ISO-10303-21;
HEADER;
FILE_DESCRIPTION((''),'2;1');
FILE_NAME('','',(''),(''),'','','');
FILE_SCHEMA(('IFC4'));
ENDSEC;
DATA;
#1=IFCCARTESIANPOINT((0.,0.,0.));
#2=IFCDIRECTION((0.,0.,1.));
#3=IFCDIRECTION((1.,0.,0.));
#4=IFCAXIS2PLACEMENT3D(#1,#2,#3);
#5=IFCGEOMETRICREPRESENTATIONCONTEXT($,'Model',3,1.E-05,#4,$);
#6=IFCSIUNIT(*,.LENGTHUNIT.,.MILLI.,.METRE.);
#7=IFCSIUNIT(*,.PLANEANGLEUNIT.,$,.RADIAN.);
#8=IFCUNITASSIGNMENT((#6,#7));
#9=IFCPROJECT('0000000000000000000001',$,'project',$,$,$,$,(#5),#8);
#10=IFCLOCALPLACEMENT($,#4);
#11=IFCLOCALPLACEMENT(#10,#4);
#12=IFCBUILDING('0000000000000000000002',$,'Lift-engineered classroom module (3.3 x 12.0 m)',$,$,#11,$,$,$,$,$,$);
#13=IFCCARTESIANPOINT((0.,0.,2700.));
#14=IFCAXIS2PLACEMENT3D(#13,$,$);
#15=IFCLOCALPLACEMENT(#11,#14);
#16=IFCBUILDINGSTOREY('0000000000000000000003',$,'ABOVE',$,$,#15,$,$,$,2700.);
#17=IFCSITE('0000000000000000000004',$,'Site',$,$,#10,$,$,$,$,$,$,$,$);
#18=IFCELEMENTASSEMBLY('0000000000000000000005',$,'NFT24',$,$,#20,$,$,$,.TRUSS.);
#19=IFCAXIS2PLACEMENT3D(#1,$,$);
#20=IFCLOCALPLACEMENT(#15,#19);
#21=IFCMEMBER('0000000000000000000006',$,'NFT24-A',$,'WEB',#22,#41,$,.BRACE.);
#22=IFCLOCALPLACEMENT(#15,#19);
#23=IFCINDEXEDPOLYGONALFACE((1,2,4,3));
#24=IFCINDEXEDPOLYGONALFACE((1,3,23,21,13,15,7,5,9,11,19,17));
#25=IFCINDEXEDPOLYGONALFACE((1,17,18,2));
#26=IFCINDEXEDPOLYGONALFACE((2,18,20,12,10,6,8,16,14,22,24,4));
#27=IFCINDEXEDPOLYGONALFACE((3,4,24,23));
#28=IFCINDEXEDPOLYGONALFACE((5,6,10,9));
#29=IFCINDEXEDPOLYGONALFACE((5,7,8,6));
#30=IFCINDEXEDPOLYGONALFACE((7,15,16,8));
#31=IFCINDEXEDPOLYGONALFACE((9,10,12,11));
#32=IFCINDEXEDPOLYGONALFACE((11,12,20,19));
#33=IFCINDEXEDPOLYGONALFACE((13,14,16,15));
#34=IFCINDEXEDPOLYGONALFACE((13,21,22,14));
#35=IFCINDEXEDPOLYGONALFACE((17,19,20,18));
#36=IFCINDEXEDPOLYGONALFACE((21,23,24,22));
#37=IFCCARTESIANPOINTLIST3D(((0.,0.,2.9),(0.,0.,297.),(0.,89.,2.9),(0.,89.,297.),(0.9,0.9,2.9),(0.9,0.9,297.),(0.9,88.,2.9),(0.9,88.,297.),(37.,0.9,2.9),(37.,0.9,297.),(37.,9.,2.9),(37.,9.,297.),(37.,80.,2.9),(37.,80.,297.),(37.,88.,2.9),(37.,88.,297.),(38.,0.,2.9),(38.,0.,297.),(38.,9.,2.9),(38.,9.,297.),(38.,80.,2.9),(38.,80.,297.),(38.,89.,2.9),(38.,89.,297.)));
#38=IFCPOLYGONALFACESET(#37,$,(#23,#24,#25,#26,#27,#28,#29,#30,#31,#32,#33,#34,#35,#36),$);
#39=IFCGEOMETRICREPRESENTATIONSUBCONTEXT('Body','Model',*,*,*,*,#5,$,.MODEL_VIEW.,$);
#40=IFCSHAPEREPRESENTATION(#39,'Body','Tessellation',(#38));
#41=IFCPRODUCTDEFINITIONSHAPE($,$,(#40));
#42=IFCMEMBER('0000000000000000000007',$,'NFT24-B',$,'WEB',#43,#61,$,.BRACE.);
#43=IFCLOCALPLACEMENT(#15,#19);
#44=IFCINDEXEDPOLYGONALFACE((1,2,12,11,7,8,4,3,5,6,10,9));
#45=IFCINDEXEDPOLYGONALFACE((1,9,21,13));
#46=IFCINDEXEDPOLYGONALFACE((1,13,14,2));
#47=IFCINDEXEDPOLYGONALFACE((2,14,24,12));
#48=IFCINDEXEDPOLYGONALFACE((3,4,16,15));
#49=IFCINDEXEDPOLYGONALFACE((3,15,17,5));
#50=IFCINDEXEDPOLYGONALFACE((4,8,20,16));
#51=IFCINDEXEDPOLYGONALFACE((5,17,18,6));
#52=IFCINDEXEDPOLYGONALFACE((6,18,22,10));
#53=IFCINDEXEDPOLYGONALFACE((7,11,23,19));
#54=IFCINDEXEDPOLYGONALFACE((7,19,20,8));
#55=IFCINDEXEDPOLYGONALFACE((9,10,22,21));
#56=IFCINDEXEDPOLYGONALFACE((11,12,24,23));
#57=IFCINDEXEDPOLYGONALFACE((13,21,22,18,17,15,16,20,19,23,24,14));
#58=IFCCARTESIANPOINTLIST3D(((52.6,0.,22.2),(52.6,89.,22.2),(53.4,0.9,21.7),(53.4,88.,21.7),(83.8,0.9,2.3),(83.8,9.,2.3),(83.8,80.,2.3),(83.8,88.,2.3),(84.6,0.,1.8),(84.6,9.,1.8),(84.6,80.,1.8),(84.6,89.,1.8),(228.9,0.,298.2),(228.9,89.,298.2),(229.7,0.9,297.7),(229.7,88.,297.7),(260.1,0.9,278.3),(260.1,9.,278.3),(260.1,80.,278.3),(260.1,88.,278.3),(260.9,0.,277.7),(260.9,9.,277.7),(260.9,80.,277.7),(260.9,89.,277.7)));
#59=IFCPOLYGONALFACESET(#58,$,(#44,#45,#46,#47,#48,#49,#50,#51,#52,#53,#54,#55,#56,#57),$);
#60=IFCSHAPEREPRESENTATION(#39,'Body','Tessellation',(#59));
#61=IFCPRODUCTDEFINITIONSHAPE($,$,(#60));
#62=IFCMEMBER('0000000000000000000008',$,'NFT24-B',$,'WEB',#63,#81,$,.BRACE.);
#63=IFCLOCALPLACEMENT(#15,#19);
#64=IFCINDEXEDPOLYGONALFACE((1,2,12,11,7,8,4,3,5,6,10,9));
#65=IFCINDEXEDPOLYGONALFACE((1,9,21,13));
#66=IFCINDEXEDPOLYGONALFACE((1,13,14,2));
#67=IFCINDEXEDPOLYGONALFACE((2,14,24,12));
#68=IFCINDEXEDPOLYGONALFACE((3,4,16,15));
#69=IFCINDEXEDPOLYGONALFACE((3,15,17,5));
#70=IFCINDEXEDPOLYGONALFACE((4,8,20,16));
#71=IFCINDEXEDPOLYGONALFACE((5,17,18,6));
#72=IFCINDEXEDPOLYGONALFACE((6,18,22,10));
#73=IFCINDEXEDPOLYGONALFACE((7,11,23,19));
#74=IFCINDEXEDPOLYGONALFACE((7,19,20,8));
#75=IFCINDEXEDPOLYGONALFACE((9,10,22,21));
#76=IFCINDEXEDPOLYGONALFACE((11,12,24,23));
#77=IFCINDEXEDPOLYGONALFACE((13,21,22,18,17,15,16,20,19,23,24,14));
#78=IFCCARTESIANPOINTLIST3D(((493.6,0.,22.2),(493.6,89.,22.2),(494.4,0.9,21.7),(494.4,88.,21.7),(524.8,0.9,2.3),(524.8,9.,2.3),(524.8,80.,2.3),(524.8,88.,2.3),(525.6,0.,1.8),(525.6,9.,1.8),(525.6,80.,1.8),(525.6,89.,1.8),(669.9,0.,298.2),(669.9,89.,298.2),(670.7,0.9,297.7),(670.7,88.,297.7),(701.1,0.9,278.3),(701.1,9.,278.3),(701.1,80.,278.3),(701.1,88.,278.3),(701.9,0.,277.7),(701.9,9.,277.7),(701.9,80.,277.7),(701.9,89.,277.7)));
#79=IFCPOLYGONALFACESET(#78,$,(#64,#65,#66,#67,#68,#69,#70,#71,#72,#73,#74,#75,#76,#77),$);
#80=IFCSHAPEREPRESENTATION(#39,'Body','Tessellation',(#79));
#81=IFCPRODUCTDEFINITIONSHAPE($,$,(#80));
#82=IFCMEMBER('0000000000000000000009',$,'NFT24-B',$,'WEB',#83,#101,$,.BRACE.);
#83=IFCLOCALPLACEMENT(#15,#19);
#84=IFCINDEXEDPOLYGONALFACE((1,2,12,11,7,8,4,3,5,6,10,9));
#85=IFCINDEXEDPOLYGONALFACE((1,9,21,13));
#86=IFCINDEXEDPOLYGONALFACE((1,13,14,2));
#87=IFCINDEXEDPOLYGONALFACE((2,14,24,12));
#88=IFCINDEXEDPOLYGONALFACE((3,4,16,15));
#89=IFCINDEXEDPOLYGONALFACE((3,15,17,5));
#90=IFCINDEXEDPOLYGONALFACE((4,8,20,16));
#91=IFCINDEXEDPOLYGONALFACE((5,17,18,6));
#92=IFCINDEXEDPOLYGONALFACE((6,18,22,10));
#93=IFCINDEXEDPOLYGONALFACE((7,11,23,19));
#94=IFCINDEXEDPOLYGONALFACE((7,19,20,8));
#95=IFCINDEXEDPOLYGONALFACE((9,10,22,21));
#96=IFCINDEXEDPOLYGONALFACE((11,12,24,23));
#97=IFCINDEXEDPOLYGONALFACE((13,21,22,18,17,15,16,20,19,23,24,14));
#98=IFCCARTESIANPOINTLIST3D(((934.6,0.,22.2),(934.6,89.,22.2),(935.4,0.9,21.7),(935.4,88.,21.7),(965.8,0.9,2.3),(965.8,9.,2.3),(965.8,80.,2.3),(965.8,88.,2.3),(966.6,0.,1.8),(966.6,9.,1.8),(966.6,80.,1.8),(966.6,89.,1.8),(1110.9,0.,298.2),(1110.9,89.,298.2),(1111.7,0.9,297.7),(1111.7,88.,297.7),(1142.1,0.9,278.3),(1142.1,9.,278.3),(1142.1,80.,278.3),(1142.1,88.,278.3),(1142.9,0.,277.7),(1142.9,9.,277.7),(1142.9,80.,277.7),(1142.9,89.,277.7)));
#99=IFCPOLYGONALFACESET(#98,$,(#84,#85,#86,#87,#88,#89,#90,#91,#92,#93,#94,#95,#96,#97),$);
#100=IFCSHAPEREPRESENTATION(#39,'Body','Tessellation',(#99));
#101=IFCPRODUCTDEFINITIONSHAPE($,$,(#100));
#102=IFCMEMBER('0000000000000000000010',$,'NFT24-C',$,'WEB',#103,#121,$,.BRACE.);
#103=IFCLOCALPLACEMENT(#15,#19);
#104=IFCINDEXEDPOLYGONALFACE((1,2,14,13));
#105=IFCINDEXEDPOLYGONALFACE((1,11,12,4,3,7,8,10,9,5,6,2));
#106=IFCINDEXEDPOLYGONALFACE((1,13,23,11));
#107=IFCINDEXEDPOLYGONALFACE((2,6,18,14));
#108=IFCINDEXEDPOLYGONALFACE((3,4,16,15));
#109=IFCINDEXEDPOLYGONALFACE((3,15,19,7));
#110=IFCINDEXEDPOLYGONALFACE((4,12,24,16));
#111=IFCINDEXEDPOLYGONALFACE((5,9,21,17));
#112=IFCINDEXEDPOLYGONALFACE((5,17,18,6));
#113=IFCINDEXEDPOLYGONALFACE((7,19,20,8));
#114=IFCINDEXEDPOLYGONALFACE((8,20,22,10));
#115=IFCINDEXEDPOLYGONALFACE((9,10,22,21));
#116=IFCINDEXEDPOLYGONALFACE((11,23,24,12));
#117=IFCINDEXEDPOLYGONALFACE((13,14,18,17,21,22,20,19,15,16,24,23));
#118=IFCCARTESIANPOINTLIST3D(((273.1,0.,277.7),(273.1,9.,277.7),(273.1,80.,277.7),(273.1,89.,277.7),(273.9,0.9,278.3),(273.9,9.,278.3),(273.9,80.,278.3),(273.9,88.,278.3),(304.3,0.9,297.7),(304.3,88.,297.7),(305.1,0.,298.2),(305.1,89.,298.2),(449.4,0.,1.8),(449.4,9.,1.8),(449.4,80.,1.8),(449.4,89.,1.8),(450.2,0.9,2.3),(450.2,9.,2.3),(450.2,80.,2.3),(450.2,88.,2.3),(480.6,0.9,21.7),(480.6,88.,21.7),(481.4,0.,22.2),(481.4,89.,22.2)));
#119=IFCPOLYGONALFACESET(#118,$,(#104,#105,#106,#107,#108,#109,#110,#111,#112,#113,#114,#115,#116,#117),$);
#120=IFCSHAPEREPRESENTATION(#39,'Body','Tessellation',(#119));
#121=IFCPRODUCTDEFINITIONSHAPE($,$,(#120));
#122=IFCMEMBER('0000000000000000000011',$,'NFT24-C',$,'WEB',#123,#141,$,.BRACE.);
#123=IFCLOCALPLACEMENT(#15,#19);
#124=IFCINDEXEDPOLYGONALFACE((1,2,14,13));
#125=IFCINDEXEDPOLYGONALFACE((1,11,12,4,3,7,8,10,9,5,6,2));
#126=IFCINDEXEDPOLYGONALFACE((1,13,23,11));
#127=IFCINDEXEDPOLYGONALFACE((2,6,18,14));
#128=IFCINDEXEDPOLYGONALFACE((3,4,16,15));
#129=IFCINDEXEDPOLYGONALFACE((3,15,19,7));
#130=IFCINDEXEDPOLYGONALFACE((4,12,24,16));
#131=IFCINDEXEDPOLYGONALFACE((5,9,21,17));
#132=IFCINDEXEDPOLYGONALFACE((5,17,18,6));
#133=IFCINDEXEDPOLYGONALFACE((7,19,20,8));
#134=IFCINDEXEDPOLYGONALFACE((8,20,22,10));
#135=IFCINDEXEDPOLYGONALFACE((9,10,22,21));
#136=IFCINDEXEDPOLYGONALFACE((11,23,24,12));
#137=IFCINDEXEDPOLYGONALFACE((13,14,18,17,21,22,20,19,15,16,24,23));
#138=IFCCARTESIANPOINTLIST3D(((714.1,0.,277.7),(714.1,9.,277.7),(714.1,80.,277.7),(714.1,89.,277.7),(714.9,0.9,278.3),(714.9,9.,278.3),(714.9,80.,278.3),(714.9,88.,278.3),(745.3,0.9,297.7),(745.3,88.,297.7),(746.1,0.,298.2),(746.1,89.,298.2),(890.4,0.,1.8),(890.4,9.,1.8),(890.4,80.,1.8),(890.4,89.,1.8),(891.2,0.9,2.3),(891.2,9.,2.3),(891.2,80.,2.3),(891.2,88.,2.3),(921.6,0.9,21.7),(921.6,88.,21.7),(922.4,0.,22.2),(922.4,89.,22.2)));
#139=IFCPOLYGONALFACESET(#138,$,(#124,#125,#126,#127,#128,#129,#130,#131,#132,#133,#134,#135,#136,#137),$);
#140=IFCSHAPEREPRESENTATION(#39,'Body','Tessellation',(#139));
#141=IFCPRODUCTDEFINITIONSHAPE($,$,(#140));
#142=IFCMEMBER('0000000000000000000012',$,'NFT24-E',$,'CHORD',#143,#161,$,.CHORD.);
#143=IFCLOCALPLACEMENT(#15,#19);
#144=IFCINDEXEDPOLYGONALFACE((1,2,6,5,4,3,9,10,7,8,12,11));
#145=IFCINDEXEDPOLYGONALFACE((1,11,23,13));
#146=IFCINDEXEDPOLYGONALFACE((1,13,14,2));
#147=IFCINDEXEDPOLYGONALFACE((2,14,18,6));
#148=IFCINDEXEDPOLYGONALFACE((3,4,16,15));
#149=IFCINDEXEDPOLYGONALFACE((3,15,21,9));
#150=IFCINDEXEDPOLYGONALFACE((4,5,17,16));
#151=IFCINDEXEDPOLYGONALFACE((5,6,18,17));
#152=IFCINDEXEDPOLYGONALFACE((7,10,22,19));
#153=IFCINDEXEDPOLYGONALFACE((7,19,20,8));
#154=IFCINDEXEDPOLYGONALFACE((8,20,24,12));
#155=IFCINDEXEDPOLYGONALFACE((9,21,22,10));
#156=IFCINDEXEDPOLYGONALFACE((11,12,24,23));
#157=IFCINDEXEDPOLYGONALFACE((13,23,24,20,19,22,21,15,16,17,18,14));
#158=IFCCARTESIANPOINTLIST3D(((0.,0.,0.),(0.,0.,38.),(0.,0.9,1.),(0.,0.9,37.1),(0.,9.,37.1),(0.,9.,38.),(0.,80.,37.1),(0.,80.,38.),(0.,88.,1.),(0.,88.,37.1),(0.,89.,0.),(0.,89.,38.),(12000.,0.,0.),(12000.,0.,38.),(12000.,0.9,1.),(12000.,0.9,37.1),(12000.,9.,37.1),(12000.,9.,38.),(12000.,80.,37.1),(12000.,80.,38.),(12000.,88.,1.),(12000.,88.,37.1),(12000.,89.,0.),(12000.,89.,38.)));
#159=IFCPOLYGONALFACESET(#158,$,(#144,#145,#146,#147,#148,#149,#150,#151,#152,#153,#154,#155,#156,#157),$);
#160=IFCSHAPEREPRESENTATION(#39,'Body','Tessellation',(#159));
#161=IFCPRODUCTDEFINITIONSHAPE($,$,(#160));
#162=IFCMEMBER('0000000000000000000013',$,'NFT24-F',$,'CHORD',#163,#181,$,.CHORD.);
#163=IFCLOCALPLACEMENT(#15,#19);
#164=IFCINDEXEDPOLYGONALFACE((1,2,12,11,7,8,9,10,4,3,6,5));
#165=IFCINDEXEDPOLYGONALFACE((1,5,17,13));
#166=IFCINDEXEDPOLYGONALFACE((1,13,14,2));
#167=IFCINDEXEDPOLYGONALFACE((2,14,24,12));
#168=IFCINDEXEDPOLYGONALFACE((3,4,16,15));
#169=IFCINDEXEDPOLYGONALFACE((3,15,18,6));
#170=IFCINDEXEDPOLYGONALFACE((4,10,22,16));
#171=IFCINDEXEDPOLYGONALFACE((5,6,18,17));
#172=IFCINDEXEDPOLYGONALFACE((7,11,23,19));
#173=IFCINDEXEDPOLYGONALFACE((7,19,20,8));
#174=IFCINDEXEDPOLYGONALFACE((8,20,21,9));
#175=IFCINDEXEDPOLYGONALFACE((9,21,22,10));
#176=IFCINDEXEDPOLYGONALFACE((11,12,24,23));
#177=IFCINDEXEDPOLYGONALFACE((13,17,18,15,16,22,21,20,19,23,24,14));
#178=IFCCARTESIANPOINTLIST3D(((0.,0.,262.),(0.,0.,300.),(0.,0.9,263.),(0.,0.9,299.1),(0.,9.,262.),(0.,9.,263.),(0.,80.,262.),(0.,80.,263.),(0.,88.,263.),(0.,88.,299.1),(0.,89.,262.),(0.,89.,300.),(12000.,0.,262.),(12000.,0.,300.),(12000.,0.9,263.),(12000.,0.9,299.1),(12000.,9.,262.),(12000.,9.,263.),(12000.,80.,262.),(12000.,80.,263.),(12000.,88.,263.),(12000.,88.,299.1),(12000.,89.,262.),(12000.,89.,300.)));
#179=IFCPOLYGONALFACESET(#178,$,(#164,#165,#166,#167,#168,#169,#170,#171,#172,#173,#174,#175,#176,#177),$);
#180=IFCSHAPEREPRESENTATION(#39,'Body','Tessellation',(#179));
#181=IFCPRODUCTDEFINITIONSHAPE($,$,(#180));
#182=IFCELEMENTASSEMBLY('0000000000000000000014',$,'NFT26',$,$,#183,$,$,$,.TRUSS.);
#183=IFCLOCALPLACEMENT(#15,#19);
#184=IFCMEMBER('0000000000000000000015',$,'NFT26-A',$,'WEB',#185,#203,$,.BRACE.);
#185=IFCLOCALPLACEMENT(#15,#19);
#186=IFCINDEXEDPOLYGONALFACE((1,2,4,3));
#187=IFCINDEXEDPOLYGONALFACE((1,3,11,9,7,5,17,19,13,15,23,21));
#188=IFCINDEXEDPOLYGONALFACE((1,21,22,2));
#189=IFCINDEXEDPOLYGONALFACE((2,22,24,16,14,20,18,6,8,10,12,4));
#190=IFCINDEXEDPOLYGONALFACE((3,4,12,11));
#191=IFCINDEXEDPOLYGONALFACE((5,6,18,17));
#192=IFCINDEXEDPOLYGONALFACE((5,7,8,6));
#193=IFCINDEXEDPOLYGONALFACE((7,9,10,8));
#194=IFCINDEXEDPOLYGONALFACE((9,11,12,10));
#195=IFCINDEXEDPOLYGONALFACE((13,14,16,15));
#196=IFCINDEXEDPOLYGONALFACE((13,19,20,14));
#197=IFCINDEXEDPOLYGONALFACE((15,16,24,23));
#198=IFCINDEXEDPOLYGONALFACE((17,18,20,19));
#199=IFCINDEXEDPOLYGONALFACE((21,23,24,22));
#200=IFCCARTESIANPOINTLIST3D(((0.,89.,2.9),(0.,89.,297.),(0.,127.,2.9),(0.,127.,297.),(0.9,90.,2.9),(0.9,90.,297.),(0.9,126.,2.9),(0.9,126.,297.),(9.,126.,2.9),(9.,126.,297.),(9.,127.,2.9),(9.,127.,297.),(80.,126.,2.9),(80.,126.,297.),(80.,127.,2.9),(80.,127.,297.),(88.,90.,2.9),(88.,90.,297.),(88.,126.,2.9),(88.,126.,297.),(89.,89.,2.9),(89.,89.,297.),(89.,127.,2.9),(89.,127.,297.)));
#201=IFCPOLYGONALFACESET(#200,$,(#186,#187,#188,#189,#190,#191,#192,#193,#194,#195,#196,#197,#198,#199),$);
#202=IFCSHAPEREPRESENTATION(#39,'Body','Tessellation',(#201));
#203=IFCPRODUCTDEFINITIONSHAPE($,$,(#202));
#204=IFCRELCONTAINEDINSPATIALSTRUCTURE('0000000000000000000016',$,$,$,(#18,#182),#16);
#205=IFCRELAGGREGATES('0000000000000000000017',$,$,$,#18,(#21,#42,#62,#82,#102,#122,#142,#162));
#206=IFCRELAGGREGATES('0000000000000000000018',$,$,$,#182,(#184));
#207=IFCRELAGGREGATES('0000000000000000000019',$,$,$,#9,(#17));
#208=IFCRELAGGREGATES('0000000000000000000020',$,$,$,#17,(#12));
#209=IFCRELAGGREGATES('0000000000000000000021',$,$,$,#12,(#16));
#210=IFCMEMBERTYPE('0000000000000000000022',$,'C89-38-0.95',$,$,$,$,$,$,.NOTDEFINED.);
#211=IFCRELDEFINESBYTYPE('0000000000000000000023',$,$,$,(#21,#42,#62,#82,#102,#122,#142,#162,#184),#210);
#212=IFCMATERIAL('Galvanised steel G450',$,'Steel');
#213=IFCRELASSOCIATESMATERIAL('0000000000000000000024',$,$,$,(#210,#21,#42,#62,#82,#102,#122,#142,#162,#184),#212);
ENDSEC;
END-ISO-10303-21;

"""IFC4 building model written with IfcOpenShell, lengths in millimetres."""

from ifc_helpers import new_model, si_unit, frame, origin, origin_with_axes, origin_2d, place, context, subcontext, project, spatial, c_section, extrude, material, material_profile, profile_set, profile_usage, type_object, element, aggregate, save


model = new_model("IFC4")

# Units and contexts
model_context = context("Model", 3, precision=1e-05, world=origin_with_axes())
body_context = subcontext(model_context, "Body", "Model", "MODEL_VIEW")
ifc_project = project(units=[si_unit("LENGTHUNIT", "METRE", prefix="MILLI"), si_unit("PLANEANGLEUNIT", "RADIAN")], contexts=[model_context])

# Site, building, storey
site_placement = place(None, origin_with_axes())
site = spatial("IfcSite", under=ifc_project, at=site_placement, Name="Site")
building_placement = place(site_placement, origin_with_axes())
building = spatial("IfcBuilding", under=site, at=building_placement, Name="Lift-engineered classroom module (3.3 x 12.0 m)")
storey_placement = place(building_placement, frame((0.0, 0.0, 2700.0)))
storey = spatial("IfcBuildingStorey", under=building, at=storey_placement, Name="ABOVE", Elevation=2700.0)

# Element assemblies, members
assembly_1_placement = place(storey_placement, frame((0.0, 44.5, 0.0)))
assembly_1 = element("IfcElementAssembly", 1, at=assembly_1_placement, inside=storey, Name="NFT24", PredefinedType="TRUSS")
ifc_material = material(Name="Galvanised steel G450", Category="Steel")
ifc_material_profile = material_profile(ifc_material, c_section(Depth=89.0, Width=38.0, WallThickness=0.9, Girth=9.0, at=origin_2d()), Name="C89-38-0.95")
ifc_profile_set = profile_set([ifc_material_profile], Name="C89-38-0.95")
ifc_profile_usage = profile_usage(ifc_profile_set)
member_type = type_object("IfcMemberType", Name="C89-38-0.95", PredefinedType="NOTDEFINED", material=ifc_profile_set)
member_1_placement = place(assembly_1_placement, frame((19.0, 0.0, 2.9), z_axis=(0.0, 0.0, 1.0), x_axis=(1.0, 0.0, 0.0)))
member_1 = element("IfcMember", 2, at=member_1_placement, type_object=member_type, material=ifc_profile_usage, Name="NFT24-A", ObjectType="WEB", PredefinedType="BRACE", context=body_context, shape_type="SweptSolid", body=[
    extrude(c_section(Depth=89.0, Width=38.0, WallThickness=0.9, Girth=9.0, at=origin_2d()), origin(), (0.0, 0.0, 1.0), 294.1),
])
member_2_placement = place(assembly_1_placement, frame((68.6, 0.0, 12.0), z_axis=(0.538459, 0.0, 0.842652), x_axis=(0.842652, 0.0, -0.538459)))
member_2 = element("IfcMember", 3, at=member_2_placement, type_object=member_type, material=ifc_profile_usage, Name="NFT24-B", ObjectType="WEB", PredefinedType="BRACE", context=body_context, shape_type="SweptSolid", body=[
    extrude(c_section(Depth=89.0, Width=38.0, WallThickness=0.9, Girth=9.0, at=origin_2d()), origin(), (0.0, 0.0, 1.0), 327.5),
])
member_3_placement = place(assembly_1_placement, frame((509.6, 0.0, 12.0), z_axis=(0.538459, 0.0, 0.842652), x_axis=(0.842652, 0.0, -0.538459)))
member_3 = element("IfcMember", 4, at=member_3_placement, type_object=member_type, material=ifc_profile_usage, Name="NFT24-B", ObjectType="WEB", PredefinedType="BRACE", context=body_context, shape_type="SweptSolid", body=[
    extrude(c_section(Depth=89.0, Width=38.0, WallThickness=0.9, Girth=9.0, at=origin_2d()), origin(), (0.0, 0.0, 1.0), 327.5),
])
member_4_placement = place(assembly_1_placement, frame((950.6, 0.0, 12.0), z_axis=(0.538459, 0.0, 0.842652), x_axis=(0.842652, 0.0, -0.538459)))
member_4 = element("IfcMember", 5, at=member_4_placement, type_object=member_type, material=ifc_profile_usage, Name="NFT24-B", ObjectType="WEB", PredefinedType="BRACE", context=body_context, shape_type="SweptSolid", body=[
    extrude(c_section(Depth=89.0, Width=38.0, WallThickness=0.9, Girth=9.0, at=origin_2d()), origin(), (0.0, 0.0, 1.0), 327.5),
])
member_5_placement = place(assembly_1_placement, frame((465.4, 0.0, 12.0), z_axis=(-0.538459, 0.0, 0.842652), x_axis=(-0.842652, 0.0, -0.538459)))
member_5 = element("IfcMember", 6, at=member_5_placement, type_object=member_type, material=ifc_profile_usage, Name="NFT24-C", ObjectType="WEB", PredefinedType="BRACE", context=body_context, shape_type="SweptSolid", body=[
    extrude(c_section(Depth=89.0, Width=38.0, WallThickness=0.9, Girth=9.0, at=origin_2d()), origin(), (0.0, 0.0, 1.0), 327.5),
])
member_6_placement = place(assembly_1_placement, frame((906.4, 0.0, 12.0), z_axis=(-0.538459, 0.0, 0.842652), x_axis=(-0.842652, 0.0, -0.538459)))
member_6 = element("IfcMember", 7, at=member_6_placement, type_object=member_type, material=ifc_profile_usage, Name="NFT24-C", ObjectType="WEB", PredefinedType="BRACE", context=body_context, shape_type="SweptSolid", body=[
    extrude(c_section(Depth=89.0, Width=38.0, WallThickness=0.9, Girth=9.0, at=origin_2d()), origin(), (0.0, 0.0, 1.0), 327.5),
])
member_7_placement = place(assembly_1_placement, frame((0.0, 0.0, 19.0), z_axis=(1.0, 0.0, 0.0), x_axis=(0.0, 0.0, 1.0)))
member_7 = element("IfcMember", 8, at=member_7_placement, type_object=member_type, material=ifc_profile_usage, Name="NFT24-E", ObjectType="CHORD", PredefinedType="CHORD", context=body_context, shape_type="SweptSolid", body=[
    extrude(c_section(Depth=89.0, Width=38.0, WallThickness=0.9, Girth=9.0, at=origin_2d()), origin(), (0.0, 0.0, 1.0), 12000.0),
])
member_8_placement = place(assembly_1_placement, frame((0.0, 0.0, 281.0), z_axis=(1.0, 0.0, 0.0), x_axis=(0.0, 0.0, -1.0)))
member_8 = element("IfcMember", 9, at=member_8_placement, type_object=member_type, material=ifc_profile_usage, Name="NFT24-F", ObjectType="CHORD", PredefinedType="CHORD", context=body_context, shape_type="SweptSolid", body=[
    extrude(c_section(Depth=89.0, Width=38.0, WallThickness=0.9, Girth=9.0, at=origin_2d()), origin(), (0.0, 0.0, 1.0), 12000.0),
])
aggregate(assembly_1, [member_1, member_2, member_3, member_4, member_5, member_6, member_7, member_8])
assembly_2_placement = place(storey_placement, frame((44.5, 89.0, 0.0)))
assembly_2 = element("IfcElementAssembly", 10, at=assembly_2_placement, inside=storey, Name="NFT26", PredefinedType="TRUSS")
member_9_placement = place(assembly_2_placement, frame((0.0, 19.0, 2.9), z_axis=(0.0, 0.0, 1.0), x_axis=(0.0, 1.0, 0.0)))
member_9 = element("IfcMember", 11, at=member_9_placement, type_object=member_type, material=ifc_profile_usage, Name="NFT26-A", ObjectType="WEB", PredefinedType="BRACE", context=body_context, shape_type="SweptSolid", body=[
    extrude(c_section(Depth=89.0, Width=38.0, WallThickness=0.9, Girth=9.0, at=origin_2d()), origin(), (0.0, 0.0, 1.0), 294.1),
])
aggregate(assembly_2, [member_9])

save(model, "model.ifc")
